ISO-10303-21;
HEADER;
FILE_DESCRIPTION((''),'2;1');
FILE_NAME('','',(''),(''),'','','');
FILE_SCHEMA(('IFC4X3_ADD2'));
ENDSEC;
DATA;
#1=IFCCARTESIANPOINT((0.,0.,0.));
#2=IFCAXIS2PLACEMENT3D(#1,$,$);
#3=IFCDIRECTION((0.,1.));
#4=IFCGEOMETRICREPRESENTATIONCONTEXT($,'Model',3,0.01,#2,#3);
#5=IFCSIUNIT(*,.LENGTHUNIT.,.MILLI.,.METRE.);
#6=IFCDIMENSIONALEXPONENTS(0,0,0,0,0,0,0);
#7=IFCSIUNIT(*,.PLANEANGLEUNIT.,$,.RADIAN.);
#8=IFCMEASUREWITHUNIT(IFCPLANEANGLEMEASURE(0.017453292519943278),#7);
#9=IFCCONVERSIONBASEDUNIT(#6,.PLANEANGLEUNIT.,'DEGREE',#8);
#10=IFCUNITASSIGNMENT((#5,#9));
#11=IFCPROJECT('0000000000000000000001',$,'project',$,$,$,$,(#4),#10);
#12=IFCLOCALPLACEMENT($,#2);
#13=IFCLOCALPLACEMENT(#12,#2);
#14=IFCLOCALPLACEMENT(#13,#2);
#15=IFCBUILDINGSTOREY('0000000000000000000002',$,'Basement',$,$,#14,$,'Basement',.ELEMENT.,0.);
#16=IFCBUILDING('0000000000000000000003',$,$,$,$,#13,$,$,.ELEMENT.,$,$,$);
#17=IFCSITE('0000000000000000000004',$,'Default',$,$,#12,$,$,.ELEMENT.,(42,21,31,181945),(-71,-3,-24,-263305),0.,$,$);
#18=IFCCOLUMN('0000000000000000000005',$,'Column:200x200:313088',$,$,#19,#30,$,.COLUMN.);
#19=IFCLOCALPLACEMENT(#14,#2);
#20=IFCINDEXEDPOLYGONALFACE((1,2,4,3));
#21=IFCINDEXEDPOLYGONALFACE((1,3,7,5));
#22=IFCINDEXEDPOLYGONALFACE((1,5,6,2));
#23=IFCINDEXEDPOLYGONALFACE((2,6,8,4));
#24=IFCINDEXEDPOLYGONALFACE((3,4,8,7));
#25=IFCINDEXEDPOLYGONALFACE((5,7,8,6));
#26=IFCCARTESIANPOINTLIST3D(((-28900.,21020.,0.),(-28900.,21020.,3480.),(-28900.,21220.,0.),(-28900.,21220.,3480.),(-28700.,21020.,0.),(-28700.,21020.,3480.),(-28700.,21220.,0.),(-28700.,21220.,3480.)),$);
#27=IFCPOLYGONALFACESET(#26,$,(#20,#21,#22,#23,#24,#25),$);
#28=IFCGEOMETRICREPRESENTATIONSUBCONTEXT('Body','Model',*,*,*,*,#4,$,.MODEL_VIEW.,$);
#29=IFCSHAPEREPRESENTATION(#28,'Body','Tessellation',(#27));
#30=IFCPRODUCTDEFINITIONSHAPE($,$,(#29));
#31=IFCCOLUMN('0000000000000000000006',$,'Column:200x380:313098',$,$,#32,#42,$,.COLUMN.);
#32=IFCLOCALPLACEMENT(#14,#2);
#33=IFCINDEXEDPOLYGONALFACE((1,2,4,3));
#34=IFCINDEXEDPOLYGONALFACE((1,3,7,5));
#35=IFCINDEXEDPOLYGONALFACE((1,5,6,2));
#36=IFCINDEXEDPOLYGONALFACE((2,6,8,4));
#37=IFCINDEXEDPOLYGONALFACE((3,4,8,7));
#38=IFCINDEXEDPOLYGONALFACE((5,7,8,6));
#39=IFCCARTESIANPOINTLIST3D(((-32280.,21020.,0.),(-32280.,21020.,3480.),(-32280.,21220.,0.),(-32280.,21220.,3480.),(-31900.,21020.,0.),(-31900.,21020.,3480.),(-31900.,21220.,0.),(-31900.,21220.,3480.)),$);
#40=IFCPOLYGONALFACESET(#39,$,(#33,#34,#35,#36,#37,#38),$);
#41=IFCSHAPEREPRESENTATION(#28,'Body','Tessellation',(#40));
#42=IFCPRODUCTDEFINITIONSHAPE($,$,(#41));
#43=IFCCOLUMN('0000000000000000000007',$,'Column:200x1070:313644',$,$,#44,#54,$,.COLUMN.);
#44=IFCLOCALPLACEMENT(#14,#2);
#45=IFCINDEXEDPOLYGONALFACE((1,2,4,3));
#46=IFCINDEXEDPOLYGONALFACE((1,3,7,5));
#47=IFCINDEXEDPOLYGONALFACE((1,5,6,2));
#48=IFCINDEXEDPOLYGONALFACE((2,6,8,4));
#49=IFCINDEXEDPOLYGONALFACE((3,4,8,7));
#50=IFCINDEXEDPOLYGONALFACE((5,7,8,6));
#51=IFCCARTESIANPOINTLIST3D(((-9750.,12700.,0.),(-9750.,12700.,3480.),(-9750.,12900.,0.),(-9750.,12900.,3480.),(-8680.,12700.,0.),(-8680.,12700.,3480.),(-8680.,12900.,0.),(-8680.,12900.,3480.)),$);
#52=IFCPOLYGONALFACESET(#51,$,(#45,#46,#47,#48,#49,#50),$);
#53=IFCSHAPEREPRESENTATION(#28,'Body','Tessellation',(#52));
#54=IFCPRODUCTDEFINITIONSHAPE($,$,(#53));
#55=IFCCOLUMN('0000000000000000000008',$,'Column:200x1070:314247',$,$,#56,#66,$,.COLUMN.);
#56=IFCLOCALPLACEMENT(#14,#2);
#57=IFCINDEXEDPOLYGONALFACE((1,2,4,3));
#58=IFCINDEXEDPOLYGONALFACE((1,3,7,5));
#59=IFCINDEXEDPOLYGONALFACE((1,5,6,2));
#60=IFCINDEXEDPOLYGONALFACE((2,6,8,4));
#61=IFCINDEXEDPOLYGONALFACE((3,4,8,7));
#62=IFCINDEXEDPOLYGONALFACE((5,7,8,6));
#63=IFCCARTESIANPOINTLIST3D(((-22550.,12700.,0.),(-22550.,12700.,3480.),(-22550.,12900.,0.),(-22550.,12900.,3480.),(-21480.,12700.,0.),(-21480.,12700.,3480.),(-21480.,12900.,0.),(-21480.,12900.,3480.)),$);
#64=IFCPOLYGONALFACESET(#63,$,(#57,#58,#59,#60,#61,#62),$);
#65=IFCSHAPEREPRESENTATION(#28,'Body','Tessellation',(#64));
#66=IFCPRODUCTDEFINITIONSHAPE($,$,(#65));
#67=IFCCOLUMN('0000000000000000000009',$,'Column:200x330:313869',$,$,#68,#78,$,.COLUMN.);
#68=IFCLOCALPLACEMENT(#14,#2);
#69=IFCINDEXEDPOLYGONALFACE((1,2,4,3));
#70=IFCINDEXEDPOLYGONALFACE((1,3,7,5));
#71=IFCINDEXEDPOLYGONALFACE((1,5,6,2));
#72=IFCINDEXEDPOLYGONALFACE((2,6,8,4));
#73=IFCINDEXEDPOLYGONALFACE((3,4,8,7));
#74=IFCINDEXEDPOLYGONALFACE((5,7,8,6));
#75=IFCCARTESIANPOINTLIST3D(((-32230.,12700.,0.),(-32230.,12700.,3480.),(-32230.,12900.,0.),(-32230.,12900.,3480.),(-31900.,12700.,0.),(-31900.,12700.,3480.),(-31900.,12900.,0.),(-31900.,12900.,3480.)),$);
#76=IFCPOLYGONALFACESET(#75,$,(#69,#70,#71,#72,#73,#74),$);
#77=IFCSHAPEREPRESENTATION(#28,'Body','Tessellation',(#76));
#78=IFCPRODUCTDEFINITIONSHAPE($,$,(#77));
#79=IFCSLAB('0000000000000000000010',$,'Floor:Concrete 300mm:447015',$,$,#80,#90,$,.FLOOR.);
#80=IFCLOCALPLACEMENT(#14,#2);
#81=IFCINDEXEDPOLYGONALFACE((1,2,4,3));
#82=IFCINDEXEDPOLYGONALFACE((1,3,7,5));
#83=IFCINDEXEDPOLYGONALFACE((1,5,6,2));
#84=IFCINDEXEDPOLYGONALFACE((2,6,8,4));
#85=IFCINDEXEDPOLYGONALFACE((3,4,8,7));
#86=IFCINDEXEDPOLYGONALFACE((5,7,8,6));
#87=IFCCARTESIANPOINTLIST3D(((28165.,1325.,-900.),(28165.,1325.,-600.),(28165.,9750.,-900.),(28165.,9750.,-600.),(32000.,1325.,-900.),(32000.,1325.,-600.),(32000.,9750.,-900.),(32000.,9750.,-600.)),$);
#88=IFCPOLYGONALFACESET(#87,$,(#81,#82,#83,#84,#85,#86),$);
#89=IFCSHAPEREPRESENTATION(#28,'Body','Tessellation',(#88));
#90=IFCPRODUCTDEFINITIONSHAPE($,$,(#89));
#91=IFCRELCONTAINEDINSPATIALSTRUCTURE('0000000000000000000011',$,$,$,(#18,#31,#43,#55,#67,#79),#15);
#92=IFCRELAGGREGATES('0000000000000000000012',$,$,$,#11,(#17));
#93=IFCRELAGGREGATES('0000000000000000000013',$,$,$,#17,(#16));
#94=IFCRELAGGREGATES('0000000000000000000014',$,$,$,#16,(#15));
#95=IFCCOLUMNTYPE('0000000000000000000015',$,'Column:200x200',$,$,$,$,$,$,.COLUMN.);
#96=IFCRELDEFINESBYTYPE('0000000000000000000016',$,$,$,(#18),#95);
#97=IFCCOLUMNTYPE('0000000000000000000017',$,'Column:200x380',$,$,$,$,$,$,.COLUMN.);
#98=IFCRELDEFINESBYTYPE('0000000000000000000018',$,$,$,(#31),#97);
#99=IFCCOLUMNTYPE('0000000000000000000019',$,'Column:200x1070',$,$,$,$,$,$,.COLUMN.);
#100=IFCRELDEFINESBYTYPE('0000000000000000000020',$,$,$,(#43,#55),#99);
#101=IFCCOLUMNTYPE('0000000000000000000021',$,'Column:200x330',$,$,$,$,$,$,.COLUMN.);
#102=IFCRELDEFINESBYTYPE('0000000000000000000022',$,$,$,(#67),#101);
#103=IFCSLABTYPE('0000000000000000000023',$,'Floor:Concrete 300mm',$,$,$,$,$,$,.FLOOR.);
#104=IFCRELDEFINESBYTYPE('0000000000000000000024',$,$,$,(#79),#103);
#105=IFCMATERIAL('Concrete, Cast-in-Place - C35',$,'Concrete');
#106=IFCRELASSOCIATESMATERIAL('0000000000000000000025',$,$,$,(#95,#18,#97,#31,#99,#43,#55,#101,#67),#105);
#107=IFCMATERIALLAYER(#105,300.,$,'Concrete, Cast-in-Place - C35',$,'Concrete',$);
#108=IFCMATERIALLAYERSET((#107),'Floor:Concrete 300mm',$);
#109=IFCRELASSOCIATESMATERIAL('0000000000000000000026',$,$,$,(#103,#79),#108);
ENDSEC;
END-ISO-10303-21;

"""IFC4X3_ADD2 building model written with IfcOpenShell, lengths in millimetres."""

from ifc_helpers import new_model, entity, si_unit, converted_unit, direction, frame, frame_2d, origin, origin_2d_with_axis, place, context, subcontext, project, spatial, rectangle, extrude, source, transform, mapped, material, layer, layer_set, layer_usage, material_profile, profile_set, profile_usage, type_object, type_shapes, element, save


model = new_model("IFC4X3_ADD2")

# Units and contexts
model_context = context("Model", 3, precision=0.01, world=origin(), true_north=direction((0.0, 1.0)))
body_context = subcontext(model_context, "Body", "Model", "MODEL_VIEW")
ifc_project = project(units=[si_unit("LENGTHUNIT", "METRE", prefix="MILLI"), converted_unit("PLANEANGLEUNIT", "DEGREE", entity("IfcPlaneAngleMeasure", 0.017453292519943278), si_unit("PLANEANGLEUNIT", "RADIAN"), dimensions=[0, 0, 0, 0, 0, 0, 0])], contexts=[model_context])

# Site, building, storey
site_placement = place(None, origin())
site = spatial("IfcSite", under=ifc_project, at=site_placement, Name="Default", CompositionType="ELEMENT", RefLatitude=(42, 21, 31, 181945), RefLongitude=(-71, -3, -24, -263305), RefElevation=0.0)
building_placement = place(site_placement, origin())
building = spatial("IfcBuilding", under=site, at=building_placement, CompositionType="ELEMENT")
storey_placement = place(building_placement, origin())
storey = spatial("IfcBuildingStorey", under=building, at=storey_placement, Name="Basement", LongName="Basement", CompositionType="ELEMENT", Elevation=0.0)

# Columns
ifc_material = material(Name="Concrete, Cast-in-Place - C35", Category="Concrete")
ifc_material_profile_1 = material_profile(ifc_material, rectangle(XDim=200.0, YDim=200.0, at=frame_2d((0.0, 0.0), x_axis=(1.0, 0.0))), Name="200x200")
ifc_profile_set_1 = profile_set([ifc_material_profile_1], Name="200x200")
ifc_profile_usage_1 = profile_usage(ifc_profile_set_1)
column_type_1 = type_object("IfcColumnType", Name="Column:200x200", PredefinedType="COLUMN", material=ifc_profile_set_1)
shared_shape_1 = source(origin(), body_context, "Body", "SweptSolid", [
    extrude(rectangle(XDim=200.0, YDim=200.0, at=frame_2d((0.0, 0.0), x_axis=(1.0, 0.0))), frame((0.0, 0.0, 0.0), z_axis=(0.0, 0.0, 1.0), x_axis=(-1.0, 0.0, 0.0)), (0.0, 0.0, 1.0), 3480.0),
])
type_shapes(column_type_1, [shared_shape_1])
for number, where, name in (
    (1, (-28800.0, 21120.0, 0.0), "Column:200x200:313088"),
):
    element("IfcColumn", number, at=place(storey_placement, frame(where)), inside=storey, type_object=column_type_1, material=ifc_profile_usage_1, Name=name, PredefinedType="COLUMN", context=body_context, shape_type="MappedRepresentation", body=[
        mapped(shared_shape_1, transform((0.0, 0.0, 0.0), scale=1.0)),
    ])
ifc_material_profile_2 = material_profile(ifc_material, rectangle(XDim=380.0, YDim=200.0, at=origin_2d_with_axis()), Name="200x380")
ifc_profile_set_2 = profile_set([ifc_material_profile_2], Name="200x380")
ifc_profile_usage_2 = profile_usage(ifc_profile_set_2)
column_type_2 = type_object("IfcColumnType", Name="Column:200x380", PredefinedType="COLUMN", material=ifc_profile_set_2)
shared_shape_2 = source(origin(), body_context, "Body", "SweptSolid", [
    extrude(rectangle(XDim=380.0, YDim=200.0, at=origin_2d_with_axis()), frame((-90.0, 0.0, 0.0), z_axis=(0.0, 0.0, 1.0), x_axis=(-1.0, 0.0, 0.0)), (0.0, 0.0, 1.0), 3480.0),
])
type_shapes(column_type_2, [shared_shape_2])
column_1_placement = place(storey_placement, frame((-32000.0, 21120.0, 0.0)))
element("IfcColumn", 2, at=column_1_placement, inside=storey, type_object=column_type_2, material=ifc_profile_usage_2, Name="Column:200x380:313098", PredefinedType="COLUMN", context=body_context, shape_type="MappedRepresentation", body=[
    mapped(shared_shape_2, transform((0.0, 0.0, 0.0), scale=1.0)),
])
ifc_material_profile_3 = material_profile(ifc_material, rectangle(XDim=1070.0, YDim=200.0, at=origin_2d_with_axis()), Name="200x1070")
ifc_profile_set_3 = profile_set([ifc_material_profile_3], Name="200x1070")
ifc_profile_usage_3 = profile_usage(ifc_profile_set_3)
column_type_3 = type_object("IfcColumnType", Name="Column:200x1070", PredefinedType="COLUMN", material=ifc_profile_set_3)
shared_shape_3 = source(origin(), body_context, "Body", "SweptSolid", [
    extrude(rectangle(XDim=1070.0, YDim=200.0, at=origin_2d_with_axis()), frame((-435.0, 0.0, 0.0), z_axis=(0.0, 0.0, 1.0), x_axis=(-1.0, 0.0, 0.0)), (0.0, 0.0, 1.0), 3480.0),
])
type_shapes(column_type_3, [shared_shape_3])
for number, where, name in (
    (3, (-8780.0, 12800.0, 0.0), "Column:200x1070:313644"),
    (4, (-21580.0, 12800.0, 0.0), "Column:200x1070:314247"),
):
    element("IfcColumn", number, at=place(storey_placement, frame(where)), inside=storey, type_object=column_type_3, material=ifc_profile_usage_3, Name=name, PredefinedType="COLUMN", context=body_context, shape_type="MappedRepresentation", body=[
        mapped(shared_shape_3, transform((0.0, 0.0, 0.0), scale=1.0)),
    ])
ifc_material_profile_4 = material_profile(ifc_material, rectangle(XDim=330.0, YDim=200.0, at=origin_2d_with_axis()), Name="200x330")
ifc_profile_set_4 = profile_set([ifc_material_profile_4], Name="200x330")
ifc_profile_usage_4 = profile_usage(ifc_profile_set_4)
column_type_4 = type_object("IfcColumnType", Name="Column:200x330", PredefinedType="COLUMN", material=ifc_profile_set_4)
shared_shape_4 = source(origin(), body_context, "Body", "SweptSolid", [
    extrude(rectangle(XDim=330.0, YDim=200.0, at=origin_2d_with_axis()), frame((-65.0, 0.0, 0.0), z_axis=(0.0, 0.0, 1.0), x_axis=(-1.0, 0.0, 0.0)), (0.0, 0.0, 1.0), 3480.0),
])
type_shapes(column_type_4, [shared_shape_4])
column_2_placement = place(storey_placement, frame((-32000.0, 12800.0, 0.0)))
element("IfcColumn", 5, at=column_2_placement, inside=storey, type_object=column_type_4, material=ifc_profile_usage_4, Name="Column:200x330:313869", PredefinedType="COLUMN", context=body_context, shape_type="MappedRepresentation", body=[
    mapped(shared_shape_4, transform((0.0, 0.0, 0.0), scale=1.0)),
])

# Slab
ifc_layer_1 = layer(ifc_material, 300.0, Name="Concrete, Cast-in-Place - C35", Category="Concrete")
ifc_layer_set_1 = layer_set([ifc_layer_1], Name="Floor:Concrete 300mm")
ifc_layer_usage_1 = layer_usage(ifc_layer_set_1, "AXIS3", "POSITIVE", 0.0)
slab_type_1 = type_object("IfcSlabType", Name="Floor:Concrete 300mm", PredefinedType="FLOOR", material=ifc_layer_set_1)
slab_1_placement = place(storey_placement, origin())
element("IfcSlab", 6, at=slab_1_placement, inside=storey, type_object=slab_type_1, material=ifc_layer_usage_1, Name="Floor:Concrete 300mm:447015", PredefinedType="FLOOR", context=body_context, shape_type="SweptSolid", body=[
    extrude(rectangle(XDim=8425.0, YDim=3835.0, at=origin_2d_with_axis()), frame((30082.5, 5537.5, -600.0), z_axis=(0.0, 0.0, -1.0), x_axis=(0.0, 1.0, 0.0)), (0.0, 0.0, 1.0), 300.0),
])

save(model, "model.ifc")
